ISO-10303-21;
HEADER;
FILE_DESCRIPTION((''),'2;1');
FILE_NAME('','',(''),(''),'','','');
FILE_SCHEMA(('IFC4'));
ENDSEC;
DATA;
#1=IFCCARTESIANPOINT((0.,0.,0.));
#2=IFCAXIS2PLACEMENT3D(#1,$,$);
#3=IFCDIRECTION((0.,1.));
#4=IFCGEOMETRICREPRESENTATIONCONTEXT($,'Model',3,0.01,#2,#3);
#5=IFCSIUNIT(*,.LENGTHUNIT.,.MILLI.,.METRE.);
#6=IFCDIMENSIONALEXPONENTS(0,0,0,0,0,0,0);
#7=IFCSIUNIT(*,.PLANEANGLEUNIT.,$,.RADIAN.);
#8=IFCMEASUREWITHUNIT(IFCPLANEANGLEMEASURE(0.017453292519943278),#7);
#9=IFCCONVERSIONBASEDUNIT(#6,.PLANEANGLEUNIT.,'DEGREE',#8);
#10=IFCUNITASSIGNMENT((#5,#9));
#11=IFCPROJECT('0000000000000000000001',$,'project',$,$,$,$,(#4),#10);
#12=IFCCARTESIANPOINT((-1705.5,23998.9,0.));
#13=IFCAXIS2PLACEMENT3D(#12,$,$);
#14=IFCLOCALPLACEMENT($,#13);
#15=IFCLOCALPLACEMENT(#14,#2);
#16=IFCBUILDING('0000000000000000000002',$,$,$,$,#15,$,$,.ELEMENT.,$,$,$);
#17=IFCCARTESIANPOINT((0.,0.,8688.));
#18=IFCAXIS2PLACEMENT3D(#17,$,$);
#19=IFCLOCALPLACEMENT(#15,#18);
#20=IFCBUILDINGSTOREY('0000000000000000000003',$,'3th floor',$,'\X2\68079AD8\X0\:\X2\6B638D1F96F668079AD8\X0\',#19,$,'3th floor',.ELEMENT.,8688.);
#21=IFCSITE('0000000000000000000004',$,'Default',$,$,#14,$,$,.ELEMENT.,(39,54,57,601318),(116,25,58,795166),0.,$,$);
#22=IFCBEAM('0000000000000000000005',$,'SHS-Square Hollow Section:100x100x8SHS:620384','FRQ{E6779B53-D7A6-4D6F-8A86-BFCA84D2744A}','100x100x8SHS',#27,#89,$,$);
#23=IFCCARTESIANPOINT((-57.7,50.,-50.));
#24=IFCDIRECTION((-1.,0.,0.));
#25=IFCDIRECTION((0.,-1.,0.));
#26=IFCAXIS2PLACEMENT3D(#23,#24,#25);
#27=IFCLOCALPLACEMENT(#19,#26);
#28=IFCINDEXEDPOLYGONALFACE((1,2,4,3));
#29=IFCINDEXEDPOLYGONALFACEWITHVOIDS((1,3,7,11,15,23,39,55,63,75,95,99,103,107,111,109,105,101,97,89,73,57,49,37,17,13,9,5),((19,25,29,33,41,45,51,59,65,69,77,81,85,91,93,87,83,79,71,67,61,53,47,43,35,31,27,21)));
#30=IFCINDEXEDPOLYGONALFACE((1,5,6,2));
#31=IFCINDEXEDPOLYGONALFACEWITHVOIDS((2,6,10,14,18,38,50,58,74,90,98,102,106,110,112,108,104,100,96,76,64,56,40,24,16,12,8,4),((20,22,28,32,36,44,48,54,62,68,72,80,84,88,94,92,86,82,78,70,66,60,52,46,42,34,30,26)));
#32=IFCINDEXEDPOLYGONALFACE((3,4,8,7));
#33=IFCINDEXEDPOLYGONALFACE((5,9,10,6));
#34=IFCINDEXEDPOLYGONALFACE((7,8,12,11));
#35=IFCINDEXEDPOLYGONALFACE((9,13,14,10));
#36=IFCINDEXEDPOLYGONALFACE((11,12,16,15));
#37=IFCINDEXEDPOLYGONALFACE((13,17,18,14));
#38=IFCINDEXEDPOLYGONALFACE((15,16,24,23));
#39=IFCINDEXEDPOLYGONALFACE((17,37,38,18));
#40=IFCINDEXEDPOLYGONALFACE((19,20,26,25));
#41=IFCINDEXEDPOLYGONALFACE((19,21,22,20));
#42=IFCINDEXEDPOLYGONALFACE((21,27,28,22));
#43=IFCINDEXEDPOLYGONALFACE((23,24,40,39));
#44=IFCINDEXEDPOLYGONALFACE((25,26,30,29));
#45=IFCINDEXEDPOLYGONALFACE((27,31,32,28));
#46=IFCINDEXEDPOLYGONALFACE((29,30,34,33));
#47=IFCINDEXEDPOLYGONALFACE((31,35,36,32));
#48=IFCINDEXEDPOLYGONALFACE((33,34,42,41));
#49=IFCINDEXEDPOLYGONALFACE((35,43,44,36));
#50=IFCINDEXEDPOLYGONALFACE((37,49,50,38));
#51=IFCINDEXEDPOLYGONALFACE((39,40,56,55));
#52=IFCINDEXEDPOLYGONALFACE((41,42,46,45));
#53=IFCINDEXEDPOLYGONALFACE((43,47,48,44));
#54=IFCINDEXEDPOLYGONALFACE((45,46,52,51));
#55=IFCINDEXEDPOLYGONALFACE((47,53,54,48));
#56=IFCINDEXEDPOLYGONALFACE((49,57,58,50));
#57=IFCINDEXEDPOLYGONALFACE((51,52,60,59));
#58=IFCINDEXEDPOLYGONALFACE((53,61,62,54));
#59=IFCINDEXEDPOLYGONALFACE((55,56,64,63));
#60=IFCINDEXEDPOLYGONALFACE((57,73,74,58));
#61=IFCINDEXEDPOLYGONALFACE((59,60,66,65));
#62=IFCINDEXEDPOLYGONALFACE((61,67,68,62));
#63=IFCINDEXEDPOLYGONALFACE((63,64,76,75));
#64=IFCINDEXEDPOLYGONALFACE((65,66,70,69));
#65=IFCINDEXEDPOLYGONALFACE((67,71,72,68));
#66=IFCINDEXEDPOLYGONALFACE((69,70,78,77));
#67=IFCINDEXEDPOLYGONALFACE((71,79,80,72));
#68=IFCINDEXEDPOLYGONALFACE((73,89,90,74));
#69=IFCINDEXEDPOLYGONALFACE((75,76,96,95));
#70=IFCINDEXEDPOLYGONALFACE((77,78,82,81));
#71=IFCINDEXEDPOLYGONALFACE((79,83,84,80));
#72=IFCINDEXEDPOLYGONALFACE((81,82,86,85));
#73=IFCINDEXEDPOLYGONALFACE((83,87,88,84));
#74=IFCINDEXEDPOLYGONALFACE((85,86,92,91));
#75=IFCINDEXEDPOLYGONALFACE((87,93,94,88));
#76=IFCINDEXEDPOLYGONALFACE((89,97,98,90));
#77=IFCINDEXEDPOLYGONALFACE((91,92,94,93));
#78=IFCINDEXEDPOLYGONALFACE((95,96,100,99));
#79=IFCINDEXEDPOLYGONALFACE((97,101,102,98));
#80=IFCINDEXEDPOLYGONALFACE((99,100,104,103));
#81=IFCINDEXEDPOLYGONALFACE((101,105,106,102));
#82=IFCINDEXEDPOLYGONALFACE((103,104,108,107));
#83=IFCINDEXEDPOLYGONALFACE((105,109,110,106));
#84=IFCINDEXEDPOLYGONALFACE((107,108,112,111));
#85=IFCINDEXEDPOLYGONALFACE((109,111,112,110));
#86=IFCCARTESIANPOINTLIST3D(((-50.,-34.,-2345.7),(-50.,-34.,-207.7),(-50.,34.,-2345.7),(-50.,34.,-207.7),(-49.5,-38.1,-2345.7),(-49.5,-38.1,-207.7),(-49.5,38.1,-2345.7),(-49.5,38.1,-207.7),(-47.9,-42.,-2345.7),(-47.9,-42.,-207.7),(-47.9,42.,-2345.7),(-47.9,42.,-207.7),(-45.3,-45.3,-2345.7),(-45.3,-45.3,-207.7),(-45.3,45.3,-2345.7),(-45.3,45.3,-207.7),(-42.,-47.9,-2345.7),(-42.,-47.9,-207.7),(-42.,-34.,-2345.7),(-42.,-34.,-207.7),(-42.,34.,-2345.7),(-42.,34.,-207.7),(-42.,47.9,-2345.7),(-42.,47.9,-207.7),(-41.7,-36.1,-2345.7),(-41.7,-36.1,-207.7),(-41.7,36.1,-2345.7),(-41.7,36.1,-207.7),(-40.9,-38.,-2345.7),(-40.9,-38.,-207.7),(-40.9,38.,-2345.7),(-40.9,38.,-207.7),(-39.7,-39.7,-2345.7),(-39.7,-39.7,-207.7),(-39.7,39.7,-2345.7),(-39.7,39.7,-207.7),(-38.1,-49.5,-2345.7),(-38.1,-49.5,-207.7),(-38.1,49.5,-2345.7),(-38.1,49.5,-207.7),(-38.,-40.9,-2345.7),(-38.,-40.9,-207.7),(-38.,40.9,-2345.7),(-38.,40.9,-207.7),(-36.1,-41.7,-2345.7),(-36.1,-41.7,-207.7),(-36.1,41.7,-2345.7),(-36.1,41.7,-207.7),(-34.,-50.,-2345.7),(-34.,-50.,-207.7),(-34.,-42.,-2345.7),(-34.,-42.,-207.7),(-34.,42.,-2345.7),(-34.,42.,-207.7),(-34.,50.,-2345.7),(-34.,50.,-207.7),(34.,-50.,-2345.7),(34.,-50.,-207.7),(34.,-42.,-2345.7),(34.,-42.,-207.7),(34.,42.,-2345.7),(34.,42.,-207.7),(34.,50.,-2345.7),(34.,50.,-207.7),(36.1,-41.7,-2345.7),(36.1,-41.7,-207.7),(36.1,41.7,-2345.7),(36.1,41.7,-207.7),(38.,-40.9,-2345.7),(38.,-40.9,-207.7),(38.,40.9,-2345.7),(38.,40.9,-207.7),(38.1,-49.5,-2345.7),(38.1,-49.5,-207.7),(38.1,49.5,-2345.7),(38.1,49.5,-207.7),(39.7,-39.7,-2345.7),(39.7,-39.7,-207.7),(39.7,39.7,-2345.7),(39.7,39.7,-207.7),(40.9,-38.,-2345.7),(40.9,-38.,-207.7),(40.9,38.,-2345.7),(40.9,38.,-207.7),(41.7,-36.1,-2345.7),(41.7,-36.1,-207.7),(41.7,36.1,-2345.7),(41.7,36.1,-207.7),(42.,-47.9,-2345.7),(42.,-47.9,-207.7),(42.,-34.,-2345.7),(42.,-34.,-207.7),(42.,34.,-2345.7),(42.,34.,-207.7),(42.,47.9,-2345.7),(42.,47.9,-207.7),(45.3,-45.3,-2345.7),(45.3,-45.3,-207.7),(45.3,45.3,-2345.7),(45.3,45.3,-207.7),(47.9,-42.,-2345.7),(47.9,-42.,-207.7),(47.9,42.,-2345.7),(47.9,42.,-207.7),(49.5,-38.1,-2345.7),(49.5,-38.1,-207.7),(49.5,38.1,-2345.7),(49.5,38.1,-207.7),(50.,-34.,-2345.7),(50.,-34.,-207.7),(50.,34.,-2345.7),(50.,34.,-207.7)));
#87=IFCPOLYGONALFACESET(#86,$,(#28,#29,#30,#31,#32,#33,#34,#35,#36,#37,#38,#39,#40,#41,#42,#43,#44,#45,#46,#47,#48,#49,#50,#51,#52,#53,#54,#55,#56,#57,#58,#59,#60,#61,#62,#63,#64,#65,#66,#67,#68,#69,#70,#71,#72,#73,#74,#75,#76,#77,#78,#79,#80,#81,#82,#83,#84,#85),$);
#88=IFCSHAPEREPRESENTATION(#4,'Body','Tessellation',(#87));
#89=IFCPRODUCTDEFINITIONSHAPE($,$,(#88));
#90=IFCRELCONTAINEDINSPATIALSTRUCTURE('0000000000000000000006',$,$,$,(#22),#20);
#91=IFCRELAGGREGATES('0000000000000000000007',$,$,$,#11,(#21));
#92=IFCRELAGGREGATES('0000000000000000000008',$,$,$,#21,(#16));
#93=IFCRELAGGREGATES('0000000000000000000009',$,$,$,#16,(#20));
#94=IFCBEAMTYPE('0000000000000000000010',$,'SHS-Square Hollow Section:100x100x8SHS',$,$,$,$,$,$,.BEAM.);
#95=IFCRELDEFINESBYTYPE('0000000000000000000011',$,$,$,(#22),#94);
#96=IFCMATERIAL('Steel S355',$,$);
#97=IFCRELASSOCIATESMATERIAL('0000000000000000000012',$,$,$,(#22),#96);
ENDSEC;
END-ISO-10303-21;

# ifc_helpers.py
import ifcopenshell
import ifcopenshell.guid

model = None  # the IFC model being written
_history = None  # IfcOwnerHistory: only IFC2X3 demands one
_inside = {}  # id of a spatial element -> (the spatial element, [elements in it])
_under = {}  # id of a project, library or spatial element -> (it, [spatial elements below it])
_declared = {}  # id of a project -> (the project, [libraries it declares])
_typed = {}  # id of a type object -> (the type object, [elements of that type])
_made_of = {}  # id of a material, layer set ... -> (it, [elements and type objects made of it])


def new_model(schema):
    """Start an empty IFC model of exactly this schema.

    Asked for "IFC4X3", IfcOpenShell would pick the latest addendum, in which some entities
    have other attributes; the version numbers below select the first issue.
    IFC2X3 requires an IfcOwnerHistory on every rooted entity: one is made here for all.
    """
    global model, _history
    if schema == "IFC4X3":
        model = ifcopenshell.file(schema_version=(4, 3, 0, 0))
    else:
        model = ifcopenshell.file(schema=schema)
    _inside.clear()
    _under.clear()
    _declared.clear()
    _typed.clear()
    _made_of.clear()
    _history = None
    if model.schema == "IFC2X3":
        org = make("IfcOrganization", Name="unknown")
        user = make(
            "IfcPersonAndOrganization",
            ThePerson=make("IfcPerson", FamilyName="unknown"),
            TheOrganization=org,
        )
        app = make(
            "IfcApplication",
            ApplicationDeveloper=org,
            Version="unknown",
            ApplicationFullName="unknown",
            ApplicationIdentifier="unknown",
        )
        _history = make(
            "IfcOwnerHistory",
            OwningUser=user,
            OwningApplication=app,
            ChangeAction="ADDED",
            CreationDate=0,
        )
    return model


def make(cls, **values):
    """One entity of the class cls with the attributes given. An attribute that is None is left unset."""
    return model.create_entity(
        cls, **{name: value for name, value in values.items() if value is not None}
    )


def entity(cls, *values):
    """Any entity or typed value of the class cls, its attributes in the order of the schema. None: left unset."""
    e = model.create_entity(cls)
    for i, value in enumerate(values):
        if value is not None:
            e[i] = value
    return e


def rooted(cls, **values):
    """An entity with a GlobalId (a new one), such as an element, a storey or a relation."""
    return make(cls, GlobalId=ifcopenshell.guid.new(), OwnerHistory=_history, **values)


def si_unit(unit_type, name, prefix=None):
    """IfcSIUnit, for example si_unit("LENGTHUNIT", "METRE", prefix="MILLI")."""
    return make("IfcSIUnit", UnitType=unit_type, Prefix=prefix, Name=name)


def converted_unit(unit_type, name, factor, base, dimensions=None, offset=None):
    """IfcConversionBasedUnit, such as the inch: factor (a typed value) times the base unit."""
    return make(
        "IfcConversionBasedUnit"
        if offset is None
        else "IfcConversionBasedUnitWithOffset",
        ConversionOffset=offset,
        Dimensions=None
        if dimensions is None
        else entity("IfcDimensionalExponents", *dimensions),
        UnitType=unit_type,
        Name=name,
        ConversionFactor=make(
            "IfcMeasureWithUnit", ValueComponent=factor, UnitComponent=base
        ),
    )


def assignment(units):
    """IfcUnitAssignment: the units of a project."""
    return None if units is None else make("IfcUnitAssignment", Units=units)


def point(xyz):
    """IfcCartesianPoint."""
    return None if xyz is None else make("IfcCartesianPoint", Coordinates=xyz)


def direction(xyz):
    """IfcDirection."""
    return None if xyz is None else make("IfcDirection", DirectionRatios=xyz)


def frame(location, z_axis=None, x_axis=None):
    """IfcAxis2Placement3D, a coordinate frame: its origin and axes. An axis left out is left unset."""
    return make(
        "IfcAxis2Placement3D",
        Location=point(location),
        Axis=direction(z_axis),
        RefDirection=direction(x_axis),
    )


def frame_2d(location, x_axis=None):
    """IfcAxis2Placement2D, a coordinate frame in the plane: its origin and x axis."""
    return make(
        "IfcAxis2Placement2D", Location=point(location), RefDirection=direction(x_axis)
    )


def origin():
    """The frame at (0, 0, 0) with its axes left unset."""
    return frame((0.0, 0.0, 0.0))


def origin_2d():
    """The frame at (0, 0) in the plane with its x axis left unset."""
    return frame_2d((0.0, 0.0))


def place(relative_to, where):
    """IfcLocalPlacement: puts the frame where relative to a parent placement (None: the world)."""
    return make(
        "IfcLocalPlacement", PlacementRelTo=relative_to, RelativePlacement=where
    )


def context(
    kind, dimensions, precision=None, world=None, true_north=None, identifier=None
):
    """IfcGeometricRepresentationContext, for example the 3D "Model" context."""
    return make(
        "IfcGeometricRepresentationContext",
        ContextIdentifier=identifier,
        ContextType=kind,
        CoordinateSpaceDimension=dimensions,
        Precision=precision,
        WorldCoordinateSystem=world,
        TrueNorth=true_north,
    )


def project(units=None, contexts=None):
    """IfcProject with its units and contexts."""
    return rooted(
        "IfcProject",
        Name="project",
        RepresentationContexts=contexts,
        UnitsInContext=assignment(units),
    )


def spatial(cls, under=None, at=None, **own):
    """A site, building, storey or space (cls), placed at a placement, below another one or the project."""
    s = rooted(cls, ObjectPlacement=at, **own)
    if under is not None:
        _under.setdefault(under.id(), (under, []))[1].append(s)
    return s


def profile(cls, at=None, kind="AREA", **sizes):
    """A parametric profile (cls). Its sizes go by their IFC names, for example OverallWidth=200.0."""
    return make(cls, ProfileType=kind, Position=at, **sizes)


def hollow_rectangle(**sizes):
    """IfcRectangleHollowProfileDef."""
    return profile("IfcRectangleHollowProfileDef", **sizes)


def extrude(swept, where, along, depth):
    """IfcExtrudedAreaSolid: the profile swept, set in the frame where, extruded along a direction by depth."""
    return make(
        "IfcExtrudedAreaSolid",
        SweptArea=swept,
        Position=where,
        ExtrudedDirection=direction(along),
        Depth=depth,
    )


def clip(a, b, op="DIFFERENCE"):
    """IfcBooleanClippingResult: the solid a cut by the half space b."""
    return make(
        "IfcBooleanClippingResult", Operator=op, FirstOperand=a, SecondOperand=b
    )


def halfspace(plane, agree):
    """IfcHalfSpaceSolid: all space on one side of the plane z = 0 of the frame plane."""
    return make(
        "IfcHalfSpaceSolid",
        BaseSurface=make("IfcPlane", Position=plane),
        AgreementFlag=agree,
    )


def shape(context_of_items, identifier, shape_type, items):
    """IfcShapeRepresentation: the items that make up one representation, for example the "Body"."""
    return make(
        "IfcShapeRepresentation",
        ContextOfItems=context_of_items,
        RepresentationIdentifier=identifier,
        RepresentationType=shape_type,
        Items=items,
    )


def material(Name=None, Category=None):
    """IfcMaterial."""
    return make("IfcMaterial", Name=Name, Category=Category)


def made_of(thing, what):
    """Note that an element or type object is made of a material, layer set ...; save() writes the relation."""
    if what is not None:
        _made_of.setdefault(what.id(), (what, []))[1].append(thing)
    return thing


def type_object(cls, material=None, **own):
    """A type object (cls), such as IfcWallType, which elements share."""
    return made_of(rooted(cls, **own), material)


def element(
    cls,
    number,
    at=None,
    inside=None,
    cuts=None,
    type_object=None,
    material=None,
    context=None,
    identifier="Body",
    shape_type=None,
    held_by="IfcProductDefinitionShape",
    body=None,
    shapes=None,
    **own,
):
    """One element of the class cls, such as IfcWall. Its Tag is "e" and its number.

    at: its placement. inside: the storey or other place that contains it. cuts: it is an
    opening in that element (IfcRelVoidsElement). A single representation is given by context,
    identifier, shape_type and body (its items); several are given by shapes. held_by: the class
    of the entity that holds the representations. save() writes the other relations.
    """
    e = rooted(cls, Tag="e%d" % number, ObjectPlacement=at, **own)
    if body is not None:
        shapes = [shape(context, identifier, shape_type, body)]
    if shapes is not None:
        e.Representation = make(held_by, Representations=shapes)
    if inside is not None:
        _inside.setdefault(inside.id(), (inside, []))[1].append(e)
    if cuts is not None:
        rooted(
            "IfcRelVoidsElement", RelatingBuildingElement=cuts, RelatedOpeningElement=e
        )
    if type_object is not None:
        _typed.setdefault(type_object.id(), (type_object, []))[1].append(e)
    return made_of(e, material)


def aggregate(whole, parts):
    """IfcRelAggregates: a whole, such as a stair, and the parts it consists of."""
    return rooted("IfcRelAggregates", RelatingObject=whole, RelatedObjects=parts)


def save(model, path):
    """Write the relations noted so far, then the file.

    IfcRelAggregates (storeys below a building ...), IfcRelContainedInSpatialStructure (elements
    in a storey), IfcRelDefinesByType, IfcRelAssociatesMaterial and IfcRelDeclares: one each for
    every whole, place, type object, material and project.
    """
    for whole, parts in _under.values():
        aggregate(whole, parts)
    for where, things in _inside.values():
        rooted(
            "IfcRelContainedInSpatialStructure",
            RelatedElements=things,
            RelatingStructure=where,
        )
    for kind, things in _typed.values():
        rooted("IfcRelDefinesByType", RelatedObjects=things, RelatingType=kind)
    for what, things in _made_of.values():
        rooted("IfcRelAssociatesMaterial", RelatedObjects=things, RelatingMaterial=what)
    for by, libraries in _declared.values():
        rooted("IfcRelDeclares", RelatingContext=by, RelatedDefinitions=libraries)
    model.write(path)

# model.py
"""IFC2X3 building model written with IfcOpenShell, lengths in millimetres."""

from ifc_helpers import new_model, entity, si_unit, converted_unit, direction, frame, origin, origin_2d, place, context, project, spatial, hollow_rectangle, extrude, clip, halfspace, material, type_object, element, save


model = new_model("IFC2X3")

# Units and contexts
model_context = context("Model", 3, precision=0.01, world=origin(), true_north=direction((0.0, 1.0)))
ifc_project = project(units=[si_unit("LENGTHUNIT", "METRE", prefix="MILLI"), converted_unit("PLANEANGLEUNIT", "DEGREE", entity("IfcPlaneAngleMeasure", 0.017453292519943278), si_unit("PLANEANGLEUNIT", "RADIAN"), dimensions=[0, 0, 0, 0, 0, 0, 0])], contexts=[model_context])

# Site, building, storey
site_placement = place(None, frame((-1705.5, 23998.9, 0.0)))
site = spatial("IfcSite", under=ifc_project, at=site_placement, Name="Default", CompositionType="ELEMENT", RefLatitude=(39, 54, 57, 601318), RefLongitude=(116, 25, 58, 795166), RefElevation=0.0)
building_placement = place(site_placement, origin())
building = spatial("IfcBuilding", under=site, at=building_placement, CompositionType="ELEMENT")
storey_placement = place(building_placement, frame((0.0, 0.0, 8688.0)))
storey = spatial("IfcBuildingStorey", under=building, at=storey_placement, Name="3th floor", ObjectType="标高:正负零标高", LongName="3th floor", CompositionType="ELEMENT", Elevation=8688.0)

# Shared definitions
ifc_material_1 = material(Name="Steel S355")

# Beam
beam_type_1 = type_object("IfcBeamType", Name="SHS-Square Hollow Section:100x100x8SHS", PredefinedType="BEAM")
beam_1_placement = place(storey_placement, frame((-57.7, 50.0, -50.0), z_axis=(-1.0, 0.0, 0.0), x_axis=(0.0, -1.0, 0.0)))
element("IfcBeam", 1, at=beam_1_placement, inside=storey, type_object=beam_type_1, material=ifc_material_1, Name="SHS-Square Hollow Section:100x100x8SHS:620384", Description="FRQ{E6779B53-D7A6-4D6F-8A86-BFCA84D2744A}", ObjectType="100x100x8SHS", context=model_context, shape_type="Clipping", body=[
    clip(clip(extrude(hollow_rectangle(XDim=100.0, YDim=100.0, WallThickness=8.0, InnerFilletRadius=8.0, OuterFilletRadius=16.0, at=origin_2d()), origin(), (0.0, 0.0, -1.0), 2551.4), halfspace(frame((50.0, -8638.0, -207.7), z_axis=(0.0, 0.0, -1.0), x_axis=(-1.0, 0.0, 0.0)), True)), halfspace(frame((50.0, -8638.0, -2345.7), z_axis=(0.0, 0.0, 1.0), x_axis=(1.0, 0.0, 0.0)), True)),
])

save(model, "model.ifc")
